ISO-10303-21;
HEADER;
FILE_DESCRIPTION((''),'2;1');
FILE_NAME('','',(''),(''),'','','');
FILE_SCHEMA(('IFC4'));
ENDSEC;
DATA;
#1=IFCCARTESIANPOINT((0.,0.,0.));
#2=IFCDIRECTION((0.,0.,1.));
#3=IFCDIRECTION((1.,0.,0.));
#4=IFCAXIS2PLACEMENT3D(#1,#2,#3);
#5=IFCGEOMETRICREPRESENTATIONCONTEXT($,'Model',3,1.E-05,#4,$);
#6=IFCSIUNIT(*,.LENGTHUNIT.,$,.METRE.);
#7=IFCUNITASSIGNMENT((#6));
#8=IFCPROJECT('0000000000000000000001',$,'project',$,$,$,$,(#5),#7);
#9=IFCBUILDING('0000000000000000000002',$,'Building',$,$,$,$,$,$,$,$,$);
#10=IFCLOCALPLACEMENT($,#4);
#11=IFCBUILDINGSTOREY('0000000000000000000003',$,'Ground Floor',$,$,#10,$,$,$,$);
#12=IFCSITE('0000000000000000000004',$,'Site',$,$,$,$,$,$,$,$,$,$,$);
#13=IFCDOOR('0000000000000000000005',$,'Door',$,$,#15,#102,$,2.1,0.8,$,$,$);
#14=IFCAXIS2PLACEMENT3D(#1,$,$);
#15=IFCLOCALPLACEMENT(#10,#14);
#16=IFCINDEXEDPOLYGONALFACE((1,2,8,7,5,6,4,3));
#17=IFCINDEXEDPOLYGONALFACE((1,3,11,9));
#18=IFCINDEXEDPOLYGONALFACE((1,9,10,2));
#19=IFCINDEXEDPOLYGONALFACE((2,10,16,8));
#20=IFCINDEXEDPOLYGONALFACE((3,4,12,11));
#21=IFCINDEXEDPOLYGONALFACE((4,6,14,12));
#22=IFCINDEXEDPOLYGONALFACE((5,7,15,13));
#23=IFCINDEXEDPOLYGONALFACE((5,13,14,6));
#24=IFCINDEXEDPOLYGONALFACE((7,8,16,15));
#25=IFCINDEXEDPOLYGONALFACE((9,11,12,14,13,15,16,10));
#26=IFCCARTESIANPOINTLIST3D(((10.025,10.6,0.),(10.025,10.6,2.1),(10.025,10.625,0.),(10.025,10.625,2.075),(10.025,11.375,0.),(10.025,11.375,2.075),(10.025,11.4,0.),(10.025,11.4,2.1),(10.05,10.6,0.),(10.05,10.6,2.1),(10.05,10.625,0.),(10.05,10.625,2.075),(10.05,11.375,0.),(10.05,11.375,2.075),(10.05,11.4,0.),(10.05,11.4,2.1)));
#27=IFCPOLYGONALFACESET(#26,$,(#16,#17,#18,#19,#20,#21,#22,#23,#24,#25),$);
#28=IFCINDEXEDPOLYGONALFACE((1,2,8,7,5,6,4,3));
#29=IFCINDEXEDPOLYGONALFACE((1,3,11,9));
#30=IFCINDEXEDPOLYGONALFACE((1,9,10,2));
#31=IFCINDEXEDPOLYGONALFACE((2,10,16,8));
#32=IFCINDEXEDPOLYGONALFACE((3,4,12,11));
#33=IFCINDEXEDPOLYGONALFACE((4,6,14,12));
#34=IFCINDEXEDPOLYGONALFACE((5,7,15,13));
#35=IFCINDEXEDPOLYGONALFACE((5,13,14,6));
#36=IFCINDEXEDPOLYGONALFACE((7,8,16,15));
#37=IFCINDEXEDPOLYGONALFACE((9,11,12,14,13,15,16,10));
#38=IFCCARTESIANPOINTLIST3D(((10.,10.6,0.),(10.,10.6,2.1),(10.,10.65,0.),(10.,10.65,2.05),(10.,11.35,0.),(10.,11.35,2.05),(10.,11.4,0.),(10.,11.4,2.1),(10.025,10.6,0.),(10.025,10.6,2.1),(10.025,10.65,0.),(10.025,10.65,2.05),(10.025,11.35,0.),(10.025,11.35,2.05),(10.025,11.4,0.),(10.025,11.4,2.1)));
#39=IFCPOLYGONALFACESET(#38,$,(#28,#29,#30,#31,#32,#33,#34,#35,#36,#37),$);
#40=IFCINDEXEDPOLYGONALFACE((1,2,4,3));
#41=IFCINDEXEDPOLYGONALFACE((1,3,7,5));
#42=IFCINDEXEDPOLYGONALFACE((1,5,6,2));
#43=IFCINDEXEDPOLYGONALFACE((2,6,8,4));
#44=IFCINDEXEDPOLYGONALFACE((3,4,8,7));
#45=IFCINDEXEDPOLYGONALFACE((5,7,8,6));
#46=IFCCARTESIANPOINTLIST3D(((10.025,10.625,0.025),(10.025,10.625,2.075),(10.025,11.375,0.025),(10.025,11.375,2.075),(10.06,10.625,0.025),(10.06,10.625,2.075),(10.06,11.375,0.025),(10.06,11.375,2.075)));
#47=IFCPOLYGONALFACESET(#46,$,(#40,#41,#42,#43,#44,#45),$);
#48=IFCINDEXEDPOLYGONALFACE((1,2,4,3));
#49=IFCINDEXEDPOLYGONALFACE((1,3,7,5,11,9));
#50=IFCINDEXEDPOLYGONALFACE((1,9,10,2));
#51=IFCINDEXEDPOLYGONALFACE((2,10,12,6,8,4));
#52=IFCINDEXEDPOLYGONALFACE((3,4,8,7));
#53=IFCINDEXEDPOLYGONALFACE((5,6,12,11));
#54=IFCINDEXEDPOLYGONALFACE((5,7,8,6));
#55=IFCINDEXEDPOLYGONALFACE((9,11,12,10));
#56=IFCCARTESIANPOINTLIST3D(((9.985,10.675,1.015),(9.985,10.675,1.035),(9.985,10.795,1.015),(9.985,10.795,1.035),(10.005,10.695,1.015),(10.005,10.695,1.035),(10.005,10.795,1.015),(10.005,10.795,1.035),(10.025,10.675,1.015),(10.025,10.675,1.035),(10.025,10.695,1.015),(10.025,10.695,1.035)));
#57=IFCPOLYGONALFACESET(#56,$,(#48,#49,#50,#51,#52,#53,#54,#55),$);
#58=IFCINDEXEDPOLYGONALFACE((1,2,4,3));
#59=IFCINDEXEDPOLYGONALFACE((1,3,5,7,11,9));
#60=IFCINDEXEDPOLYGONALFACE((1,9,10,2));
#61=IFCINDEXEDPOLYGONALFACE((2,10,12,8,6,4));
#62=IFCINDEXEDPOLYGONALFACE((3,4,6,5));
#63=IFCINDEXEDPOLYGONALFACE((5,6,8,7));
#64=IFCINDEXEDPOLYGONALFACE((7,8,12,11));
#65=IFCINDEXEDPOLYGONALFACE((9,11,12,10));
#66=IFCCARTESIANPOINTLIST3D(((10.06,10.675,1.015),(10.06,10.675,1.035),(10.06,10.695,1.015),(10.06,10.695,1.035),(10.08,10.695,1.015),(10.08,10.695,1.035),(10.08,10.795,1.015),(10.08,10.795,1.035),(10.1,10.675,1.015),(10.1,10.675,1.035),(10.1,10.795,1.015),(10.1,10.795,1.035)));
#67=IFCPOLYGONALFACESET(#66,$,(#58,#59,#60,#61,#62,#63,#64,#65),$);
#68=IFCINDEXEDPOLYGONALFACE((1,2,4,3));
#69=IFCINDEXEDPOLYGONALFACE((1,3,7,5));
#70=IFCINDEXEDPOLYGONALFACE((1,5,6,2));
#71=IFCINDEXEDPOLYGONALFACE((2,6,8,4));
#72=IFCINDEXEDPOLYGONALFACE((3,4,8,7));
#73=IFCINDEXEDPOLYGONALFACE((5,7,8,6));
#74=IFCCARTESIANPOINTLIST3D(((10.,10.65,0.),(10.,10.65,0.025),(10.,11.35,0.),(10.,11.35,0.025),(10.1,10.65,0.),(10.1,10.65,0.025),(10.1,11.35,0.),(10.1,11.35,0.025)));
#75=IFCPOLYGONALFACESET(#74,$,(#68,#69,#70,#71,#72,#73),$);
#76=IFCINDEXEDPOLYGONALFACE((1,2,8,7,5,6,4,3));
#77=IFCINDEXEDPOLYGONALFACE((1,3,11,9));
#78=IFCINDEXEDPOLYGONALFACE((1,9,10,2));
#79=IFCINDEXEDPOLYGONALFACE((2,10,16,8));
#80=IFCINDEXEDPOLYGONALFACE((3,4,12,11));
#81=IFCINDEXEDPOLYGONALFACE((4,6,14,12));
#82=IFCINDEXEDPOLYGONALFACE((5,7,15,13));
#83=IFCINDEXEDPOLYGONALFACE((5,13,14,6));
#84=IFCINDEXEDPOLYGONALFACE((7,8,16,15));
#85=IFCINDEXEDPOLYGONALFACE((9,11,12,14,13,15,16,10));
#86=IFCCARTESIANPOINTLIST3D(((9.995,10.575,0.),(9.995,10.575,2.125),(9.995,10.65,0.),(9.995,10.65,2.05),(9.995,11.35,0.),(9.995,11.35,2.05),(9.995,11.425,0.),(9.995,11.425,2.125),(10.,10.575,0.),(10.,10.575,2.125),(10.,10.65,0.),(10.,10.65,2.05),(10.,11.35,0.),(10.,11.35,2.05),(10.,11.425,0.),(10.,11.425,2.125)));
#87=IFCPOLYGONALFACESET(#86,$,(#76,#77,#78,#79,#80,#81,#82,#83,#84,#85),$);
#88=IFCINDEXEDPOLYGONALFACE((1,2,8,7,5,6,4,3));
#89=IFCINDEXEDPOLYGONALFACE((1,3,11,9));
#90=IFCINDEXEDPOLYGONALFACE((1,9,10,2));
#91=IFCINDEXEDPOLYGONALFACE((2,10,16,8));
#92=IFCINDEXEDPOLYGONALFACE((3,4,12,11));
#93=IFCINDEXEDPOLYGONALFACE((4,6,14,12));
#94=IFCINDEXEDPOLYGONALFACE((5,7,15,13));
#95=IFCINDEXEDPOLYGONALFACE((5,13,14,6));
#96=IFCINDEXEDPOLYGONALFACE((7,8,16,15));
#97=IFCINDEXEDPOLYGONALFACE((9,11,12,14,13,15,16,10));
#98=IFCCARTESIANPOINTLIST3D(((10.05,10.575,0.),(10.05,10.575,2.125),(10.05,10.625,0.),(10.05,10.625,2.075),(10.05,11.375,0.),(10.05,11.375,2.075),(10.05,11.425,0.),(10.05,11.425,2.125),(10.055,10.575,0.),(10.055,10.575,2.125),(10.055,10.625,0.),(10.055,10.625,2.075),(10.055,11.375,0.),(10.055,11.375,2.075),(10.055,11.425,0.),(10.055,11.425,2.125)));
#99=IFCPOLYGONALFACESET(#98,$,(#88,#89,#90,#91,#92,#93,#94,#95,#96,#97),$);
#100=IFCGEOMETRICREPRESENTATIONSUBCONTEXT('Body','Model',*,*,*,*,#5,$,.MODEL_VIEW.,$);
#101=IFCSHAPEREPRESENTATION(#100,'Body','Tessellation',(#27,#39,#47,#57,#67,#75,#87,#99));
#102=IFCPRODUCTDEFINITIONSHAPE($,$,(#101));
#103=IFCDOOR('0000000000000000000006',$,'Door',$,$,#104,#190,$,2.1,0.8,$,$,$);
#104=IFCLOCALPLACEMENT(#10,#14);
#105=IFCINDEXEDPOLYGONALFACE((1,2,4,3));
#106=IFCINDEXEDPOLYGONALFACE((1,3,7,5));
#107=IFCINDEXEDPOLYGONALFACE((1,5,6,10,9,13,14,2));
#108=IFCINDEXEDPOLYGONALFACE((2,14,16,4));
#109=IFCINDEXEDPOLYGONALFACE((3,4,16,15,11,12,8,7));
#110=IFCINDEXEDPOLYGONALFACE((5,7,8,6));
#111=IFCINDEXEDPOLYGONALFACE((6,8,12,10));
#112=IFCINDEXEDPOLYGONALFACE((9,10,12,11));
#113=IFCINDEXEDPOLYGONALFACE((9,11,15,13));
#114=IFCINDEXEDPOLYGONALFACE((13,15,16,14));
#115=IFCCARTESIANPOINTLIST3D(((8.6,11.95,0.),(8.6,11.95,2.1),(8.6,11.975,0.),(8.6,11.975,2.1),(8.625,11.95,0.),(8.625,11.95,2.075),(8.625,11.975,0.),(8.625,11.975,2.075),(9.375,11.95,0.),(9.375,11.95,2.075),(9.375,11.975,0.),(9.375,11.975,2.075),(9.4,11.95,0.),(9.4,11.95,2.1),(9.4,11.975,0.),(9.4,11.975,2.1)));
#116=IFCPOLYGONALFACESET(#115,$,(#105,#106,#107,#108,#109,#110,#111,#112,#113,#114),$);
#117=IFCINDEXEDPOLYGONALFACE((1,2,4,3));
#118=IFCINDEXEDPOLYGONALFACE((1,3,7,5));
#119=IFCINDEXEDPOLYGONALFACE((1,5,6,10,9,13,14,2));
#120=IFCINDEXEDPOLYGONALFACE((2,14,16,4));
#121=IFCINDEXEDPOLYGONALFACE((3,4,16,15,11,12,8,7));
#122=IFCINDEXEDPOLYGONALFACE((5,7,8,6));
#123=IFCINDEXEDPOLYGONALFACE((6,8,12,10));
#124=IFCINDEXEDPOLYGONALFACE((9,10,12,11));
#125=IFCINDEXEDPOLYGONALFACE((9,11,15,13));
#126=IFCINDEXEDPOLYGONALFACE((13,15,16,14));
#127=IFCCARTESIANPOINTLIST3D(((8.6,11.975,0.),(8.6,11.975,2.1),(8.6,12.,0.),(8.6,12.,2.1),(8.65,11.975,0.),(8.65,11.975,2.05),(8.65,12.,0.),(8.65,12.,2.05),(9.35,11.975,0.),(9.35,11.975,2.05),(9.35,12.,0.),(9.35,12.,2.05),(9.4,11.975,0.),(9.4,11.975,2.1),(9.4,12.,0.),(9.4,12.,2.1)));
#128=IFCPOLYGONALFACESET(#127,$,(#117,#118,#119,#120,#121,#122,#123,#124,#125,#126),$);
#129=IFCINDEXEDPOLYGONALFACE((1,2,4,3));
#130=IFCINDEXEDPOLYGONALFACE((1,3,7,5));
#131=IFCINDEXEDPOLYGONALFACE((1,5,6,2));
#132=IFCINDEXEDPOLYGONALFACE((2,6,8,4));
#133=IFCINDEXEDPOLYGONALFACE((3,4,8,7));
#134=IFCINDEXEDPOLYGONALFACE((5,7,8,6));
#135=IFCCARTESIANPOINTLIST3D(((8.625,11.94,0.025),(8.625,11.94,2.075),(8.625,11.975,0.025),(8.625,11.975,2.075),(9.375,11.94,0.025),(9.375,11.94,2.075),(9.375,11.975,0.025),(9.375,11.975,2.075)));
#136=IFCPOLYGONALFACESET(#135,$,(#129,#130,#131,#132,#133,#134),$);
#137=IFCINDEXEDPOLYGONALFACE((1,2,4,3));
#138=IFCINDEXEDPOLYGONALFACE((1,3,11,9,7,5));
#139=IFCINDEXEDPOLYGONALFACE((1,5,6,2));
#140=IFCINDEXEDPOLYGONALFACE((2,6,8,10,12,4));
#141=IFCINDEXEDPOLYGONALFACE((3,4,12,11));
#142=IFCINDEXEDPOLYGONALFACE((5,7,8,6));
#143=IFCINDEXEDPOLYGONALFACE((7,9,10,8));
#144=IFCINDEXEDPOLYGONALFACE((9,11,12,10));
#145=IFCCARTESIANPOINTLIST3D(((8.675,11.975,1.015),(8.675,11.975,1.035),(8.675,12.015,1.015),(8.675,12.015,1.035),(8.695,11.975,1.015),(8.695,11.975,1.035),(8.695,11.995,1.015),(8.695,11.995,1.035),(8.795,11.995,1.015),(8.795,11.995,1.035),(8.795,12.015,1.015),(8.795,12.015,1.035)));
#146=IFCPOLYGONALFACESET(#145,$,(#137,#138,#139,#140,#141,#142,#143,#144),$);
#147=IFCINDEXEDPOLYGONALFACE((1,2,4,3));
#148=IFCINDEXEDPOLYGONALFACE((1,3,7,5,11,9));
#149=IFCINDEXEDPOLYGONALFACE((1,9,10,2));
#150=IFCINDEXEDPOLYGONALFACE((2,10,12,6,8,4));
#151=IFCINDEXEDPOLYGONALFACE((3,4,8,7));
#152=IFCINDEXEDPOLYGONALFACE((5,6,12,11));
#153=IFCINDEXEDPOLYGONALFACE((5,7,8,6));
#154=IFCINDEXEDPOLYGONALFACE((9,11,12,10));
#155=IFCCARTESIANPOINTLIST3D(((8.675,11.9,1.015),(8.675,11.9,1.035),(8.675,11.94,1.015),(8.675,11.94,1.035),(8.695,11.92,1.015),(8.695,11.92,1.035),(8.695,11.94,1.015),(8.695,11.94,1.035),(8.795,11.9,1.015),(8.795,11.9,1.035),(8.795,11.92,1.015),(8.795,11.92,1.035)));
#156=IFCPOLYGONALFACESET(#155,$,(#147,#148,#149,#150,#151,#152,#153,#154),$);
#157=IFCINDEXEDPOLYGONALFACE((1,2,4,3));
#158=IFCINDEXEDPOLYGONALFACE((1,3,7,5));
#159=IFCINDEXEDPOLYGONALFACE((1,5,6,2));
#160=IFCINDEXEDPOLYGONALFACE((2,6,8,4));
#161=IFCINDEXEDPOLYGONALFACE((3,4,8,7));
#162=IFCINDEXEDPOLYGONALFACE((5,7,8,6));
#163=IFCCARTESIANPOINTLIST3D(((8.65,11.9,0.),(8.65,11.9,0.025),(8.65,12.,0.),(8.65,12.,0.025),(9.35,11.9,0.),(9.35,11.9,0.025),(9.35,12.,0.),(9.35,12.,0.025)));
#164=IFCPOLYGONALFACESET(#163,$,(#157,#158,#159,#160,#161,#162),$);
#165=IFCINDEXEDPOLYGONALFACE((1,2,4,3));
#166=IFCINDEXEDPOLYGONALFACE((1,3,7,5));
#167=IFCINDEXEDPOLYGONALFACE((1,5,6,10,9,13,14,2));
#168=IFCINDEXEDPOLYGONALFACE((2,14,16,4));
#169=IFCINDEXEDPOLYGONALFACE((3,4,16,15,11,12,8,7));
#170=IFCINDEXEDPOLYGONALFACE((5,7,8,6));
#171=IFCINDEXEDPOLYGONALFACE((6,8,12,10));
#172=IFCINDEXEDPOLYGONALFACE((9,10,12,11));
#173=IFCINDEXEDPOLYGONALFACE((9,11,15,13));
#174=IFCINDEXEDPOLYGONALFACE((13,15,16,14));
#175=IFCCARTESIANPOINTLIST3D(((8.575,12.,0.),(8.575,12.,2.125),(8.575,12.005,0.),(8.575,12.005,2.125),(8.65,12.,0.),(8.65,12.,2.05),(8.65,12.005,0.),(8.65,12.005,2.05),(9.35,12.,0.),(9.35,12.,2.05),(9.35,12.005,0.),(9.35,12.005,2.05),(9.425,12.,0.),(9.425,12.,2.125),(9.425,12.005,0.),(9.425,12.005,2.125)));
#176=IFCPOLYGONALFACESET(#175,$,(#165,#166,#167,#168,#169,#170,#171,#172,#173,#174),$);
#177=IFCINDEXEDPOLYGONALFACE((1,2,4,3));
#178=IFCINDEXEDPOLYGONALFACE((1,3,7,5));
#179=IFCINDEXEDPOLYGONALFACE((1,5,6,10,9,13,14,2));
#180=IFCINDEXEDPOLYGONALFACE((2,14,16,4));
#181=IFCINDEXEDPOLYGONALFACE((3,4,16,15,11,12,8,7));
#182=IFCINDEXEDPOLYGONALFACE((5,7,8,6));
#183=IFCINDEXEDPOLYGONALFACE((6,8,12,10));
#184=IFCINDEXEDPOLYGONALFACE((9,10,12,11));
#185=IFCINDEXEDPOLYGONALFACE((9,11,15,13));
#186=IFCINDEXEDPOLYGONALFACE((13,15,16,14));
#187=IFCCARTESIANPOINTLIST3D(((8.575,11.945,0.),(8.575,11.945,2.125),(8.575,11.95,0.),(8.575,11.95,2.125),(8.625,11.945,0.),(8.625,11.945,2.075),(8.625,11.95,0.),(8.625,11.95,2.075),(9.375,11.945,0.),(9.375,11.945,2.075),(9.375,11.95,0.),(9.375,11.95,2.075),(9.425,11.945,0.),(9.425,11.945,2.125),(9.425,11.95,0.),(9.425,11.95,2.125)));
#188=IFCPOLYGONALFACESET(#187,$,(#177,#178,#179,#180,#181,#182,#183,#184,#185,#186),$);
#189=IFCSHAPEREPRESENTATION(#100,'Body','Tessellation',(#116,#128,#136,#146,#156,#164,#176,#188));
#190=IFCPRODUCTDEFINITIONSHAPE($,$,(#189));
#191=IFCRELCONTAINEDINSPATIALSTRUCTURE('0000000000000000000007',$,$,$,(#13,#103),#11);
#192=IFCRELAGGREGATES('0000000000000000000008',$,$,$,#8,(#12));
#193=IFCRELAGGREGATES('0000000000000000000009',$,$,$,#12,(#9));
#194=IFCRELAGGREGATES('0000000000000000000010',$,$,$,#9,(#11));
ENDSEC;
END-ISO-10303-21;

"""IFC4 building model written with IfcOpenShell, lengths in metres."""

from ifc_helpers import new_model, si_unit, frame, origin_with_axes, place, context, subcontext, project, spatial, line, indexed_curve, outline, extrude, element, save


model = new_model("IFC4")

# Units and contexts
model_context = context("Model", 3, precision=1e-05, world=origin_with_axes())
body_context = subcontext(model_context, "Body", "Model", "MODEL_VIEW")
ifc_project = project(units=[si_unit("LENGTHUNIT", "METRE")], contexts=[model_context])

# Site, building, storey
site = spatial("IfcSite", under=ifc_project, Name="Site")
building = spatial("IfcBuilding", under=site, Name="Building")
storey_placement = place(None, origin_with_axes())
storey = spatial("IfcBuildingStorey", under=building, at=storey_placement, Name="Ground Floor")

# Doors
door_1_placement = place(storey_placement, frame((10.0, 11.4, 0.0), z_axis=(0.0, 0.0, 1.0), x_axis=(0.0, -1.0, 0.0)))
element("IfcDoor", 1, at=door_1_placement, inside=storey, Name="Door", OverallHeight=2.1, OverallWidth=0.8, context=body_context, shape_type="SweptSolid", body=[
    extrude(outline(indexed_curve([(0.0, 0.0), (0.0, 2.1), (0.8, 2.1), (0.8, 0.0), (0.775, 0.0), (0.775, 2.075), (0.025, 2.075), (0.025, 0.0)], segments=[line(1, 2, 3, 4, 5, 6, 7, 8, 1)])), frame((0.0, 0.025, 0.0), z_axis=(0.0, -1.0, 0.0), x_axis=(1.0, 0.0, 0.0)), (0.0, 0.0, -1.0), 0.025),
    extrude(outline(indexed_curve([(0.0, 0.0), (0.0, 2.1), (0.8, 2.1), (0.8, 0.0), (0.75, 0.0), (0.75, 2.05), (0.05, 2.05), (0.05, 0.0)], segments=[line(1, 2, 3, 4, 5, 6, 7, 8, 1)])), frame((0.0, 0.0, 0.0), z_axis=(0.0, -1.0, 0.0), x_axis=(1.0, 0.0, 0.0)), (0.0, 0.0, -1.0), 0.025),
    extrude(outline(indexed_curve([(0.0, 0.0), (0.75, 0.0), (0.75, 0.035), (0.0, 0.035)], segments=[line(1, 2, 3, 4, 1)])), frame((0.025, 0.025, 0.025), z_axis=(0.0, 0.0, 1.0), x_axis=(1.0, 0.0, 0.0)), (0.0, 0.0, 1.0), 2.05),
    extrude(outline(indexed_curve([(0.0, 0.0), (0.0, -0.04), (-0.12, -0.04), (-0.12, -0.02), (-0.02, -0.02), (-0.02, 0.0)], segments=[line(1, 2, 3, 4, 5, 6, 1)])), frame((0.725, 0.025, 1.015), z_axis=(0.0, 0.0, 1.0), x_axis=(1.0, 0.0, 0.0)), (0.0, 0.0, 1.0), 0.02),
    extrude(outline(indexed_curve([(0.0, 0.0), (0.0, 0.04), (-0.12, 0.04), (-0.12, 0.02), (-0.02, 0.02), (-0.02, 0.0)], segments=[line(1, 2, 3, 4, 5, 6, 1)])), frame((0.725, 0.06, 1.015), z_axis=(0.0, 0.0, 1.0), x_axis=(1.0, 0.0, 0.0)), (0.0, 0.0, 1.0), 0.02),
    extrude(outline(indexed_curve([(0.0, 0.0), (0.7, 0.0), (0.7, 0.1), (0.0, 0.1)], segments=[line(1, 2, 3, 4, 1)])), frame((0.05, 0.0, 0.0), z_axis=(0.0, 0.0, 1.0), x_axis=(1.0, 0.0, 0.0)), (0.0, 0.0, 1.0), 0.025),
    extrude(outline(indexed_curve([(0.0, 0.0), (0.0, 2.125), (0.85, 2.125), (0.85, 0.0), (0.775, 0.0), (0.775, 2.05), (0.075, 2.05), (0.075, 0.0)], segments=[line(1, 2, 3, 4, 5, 6, 7, 8, 1)])), frame((-0.025, -0.005, 0.0), z_axis=(0.0, -1.0, 0.0), x_axis=(1.0, 0.0, 0.0)), (0.0, 0.0, -1.0), 0.005),
    extrude(outline(indexed_curve([(0.0, 0.0), (0.0, 2.125), (0.85, 2.125), (0.85, 0.0), (0.8, 0.0), (0.8, 2.075), (0.05, 2.075), (0.05, 0.0)], segments=[line(1, 2, 3, 4, 5, 6, 7, 8, 1)])), frame((-0.025, 0.05, 0.0), z_axis=(0.0, -1.0, 0.0), x_axis=(1.0, 0.0, 0.0)), (0.0, 0.0, -1.0), 0.005),
])
door_2_placement = place(storey_placement, frame((9.4, 12.0, 0.0), z_axis=(0.0, 0.0, 1.0), x_axis=(-1.0, 0.0, 0.0)))
element("IfcDoor", 2, at=door_2_placement, inside=storey, Name="Door", OverallHeight=2.1, OverallWidth=0.8, context=body_context, shape_type="SweptSolid", body=[
    extrude(outline(indexed_curve([(0.0, 0.0), (0.0, 2.1), (0.8, 2.1), (0.8, 0.0), (0.775, 0.0), (0.775, 2.075), (0.025, 2.075), (0.025, 0.0)], segments=[line(1, 2, 3, 4, 5, 6, 7, 8, 1)])), frame((0.0, 0.025, 0.0), z_axis=(0.0, -1.0, 0.0), x_axis=(1.0, 0.0, 0.0)), (0.0, 0.0, -1.0), 0.025),
    extrude(outline(indexed_curve([(0.0, 0.0), (0.0, 2.1), (0.8, 2.1), (0.8, 0.0), (0.75, 0.0), (0.75, 2.05), (0.05, 2.05), (0.05, 0.0)], segments=[line(1, 2, 3, 4, 5, 6, 7, 8, 1)])), frame((0.0, 0.0, 0.0), z_axis=(0.0, -1.0, 0.0), x_axis=(1.0, 0.0, 0.0)), (0.0, 0.0, -1.0), 0.025),
    extrude(outline(indexed_curve([(0.0, 0.0), (0.75, 0.0), (0.75, 0.035), (0.0, 0.035)], segments=[line(1, 2, 3, 4, 1)])), frame((0.025, 0.025, 0.025), z_axis=(0.0, 0.0, 1.0), x_axis=(1.0, 0.0, 0.0)), (0.0, 0.0, 1.0), 2.05),
    extrude(outline(indexed_curve([(0.0, 0.0), (0.0, -0.04), (-0.12, -0.04), (-0.12, -0.02), (-0.02, -0.02), (-0.02, 0.0)], segments=[line(1, 2, 3, 4, 5, 6, 1)])), frame((0.725, 0.025, 1.015), z_axis=(0.0, 0.0, 1.0), x_axis=(1.0, 0.0, 0.0)), (0.0, 0.0, 1.0), 0.02),
    extrude(outline(indexed_curve([(0.0, 0.0), (0.0, 0.04), (-0.12, 0.04), (-0.12, 0.02), (-0.02, 0.02), (-0.02, 0.0)], segments=[line(1, 2, 3, 4, 5, 6, 1)])), frame((0.725, 0.06, 1.015), z_axis=(0.0, 0.0, 1.0), x_axis=(1.0, 0.0, 0.0)), (0.0, 0.0, 1.0), 0.02),
    extrude(outline(indexed_curve([(0.0, 0.0), (0.7, 0.0), (0.7, 0.1), (0.0, 0.1)], segments=[line(1, 2, 3, 4, 1)])), frame((0.05, 0.0, 0.0), z_axis=(0.0, 0.0, 1.0), x_axis=(1.0, 0.0, 0.0)), (0.0, 0.0, 1.0), 0.025),
    extrude(outline(indexed_curve([(0.0, 0.0), (0.0, 2.125), (0.85, 2.125), (0.85, 0.0), (0.775, 0.0), (0.775, 2.05), (0.075, 2.05), (0.075, 0.0)], segments=[line(1, 2, 3, 4, 5, 6, 7, 8, 1)])), frame((-0.025, -0.005, 0.0), z_axis=(0.0, -1.0, 0.0), x_axis=(1.0, 0.0, 0.0)), (0.0, 0.0, -1.0), 0.005),
    extrude(outline(indexed_curve([(0.0, 0.0), (0.0, 2.125), (0.85, 2.125), (0.85, 0.0), (0.8, 0.0), (0.8, 2.075), (0.05, 2.075), (0.05, 0.0)], segments=[line(1, 2, 3, 4, 5, 6, 7, 8, 1)])), frame((-0.025, 0.05, 0.0), z_axis=(0.0, -1.0, 0.0), x_axis=(1.0, 0.0, 0.0)), (0.0, 0.0, -1.0), 0.005),
])

save(model, "model.ifc")
